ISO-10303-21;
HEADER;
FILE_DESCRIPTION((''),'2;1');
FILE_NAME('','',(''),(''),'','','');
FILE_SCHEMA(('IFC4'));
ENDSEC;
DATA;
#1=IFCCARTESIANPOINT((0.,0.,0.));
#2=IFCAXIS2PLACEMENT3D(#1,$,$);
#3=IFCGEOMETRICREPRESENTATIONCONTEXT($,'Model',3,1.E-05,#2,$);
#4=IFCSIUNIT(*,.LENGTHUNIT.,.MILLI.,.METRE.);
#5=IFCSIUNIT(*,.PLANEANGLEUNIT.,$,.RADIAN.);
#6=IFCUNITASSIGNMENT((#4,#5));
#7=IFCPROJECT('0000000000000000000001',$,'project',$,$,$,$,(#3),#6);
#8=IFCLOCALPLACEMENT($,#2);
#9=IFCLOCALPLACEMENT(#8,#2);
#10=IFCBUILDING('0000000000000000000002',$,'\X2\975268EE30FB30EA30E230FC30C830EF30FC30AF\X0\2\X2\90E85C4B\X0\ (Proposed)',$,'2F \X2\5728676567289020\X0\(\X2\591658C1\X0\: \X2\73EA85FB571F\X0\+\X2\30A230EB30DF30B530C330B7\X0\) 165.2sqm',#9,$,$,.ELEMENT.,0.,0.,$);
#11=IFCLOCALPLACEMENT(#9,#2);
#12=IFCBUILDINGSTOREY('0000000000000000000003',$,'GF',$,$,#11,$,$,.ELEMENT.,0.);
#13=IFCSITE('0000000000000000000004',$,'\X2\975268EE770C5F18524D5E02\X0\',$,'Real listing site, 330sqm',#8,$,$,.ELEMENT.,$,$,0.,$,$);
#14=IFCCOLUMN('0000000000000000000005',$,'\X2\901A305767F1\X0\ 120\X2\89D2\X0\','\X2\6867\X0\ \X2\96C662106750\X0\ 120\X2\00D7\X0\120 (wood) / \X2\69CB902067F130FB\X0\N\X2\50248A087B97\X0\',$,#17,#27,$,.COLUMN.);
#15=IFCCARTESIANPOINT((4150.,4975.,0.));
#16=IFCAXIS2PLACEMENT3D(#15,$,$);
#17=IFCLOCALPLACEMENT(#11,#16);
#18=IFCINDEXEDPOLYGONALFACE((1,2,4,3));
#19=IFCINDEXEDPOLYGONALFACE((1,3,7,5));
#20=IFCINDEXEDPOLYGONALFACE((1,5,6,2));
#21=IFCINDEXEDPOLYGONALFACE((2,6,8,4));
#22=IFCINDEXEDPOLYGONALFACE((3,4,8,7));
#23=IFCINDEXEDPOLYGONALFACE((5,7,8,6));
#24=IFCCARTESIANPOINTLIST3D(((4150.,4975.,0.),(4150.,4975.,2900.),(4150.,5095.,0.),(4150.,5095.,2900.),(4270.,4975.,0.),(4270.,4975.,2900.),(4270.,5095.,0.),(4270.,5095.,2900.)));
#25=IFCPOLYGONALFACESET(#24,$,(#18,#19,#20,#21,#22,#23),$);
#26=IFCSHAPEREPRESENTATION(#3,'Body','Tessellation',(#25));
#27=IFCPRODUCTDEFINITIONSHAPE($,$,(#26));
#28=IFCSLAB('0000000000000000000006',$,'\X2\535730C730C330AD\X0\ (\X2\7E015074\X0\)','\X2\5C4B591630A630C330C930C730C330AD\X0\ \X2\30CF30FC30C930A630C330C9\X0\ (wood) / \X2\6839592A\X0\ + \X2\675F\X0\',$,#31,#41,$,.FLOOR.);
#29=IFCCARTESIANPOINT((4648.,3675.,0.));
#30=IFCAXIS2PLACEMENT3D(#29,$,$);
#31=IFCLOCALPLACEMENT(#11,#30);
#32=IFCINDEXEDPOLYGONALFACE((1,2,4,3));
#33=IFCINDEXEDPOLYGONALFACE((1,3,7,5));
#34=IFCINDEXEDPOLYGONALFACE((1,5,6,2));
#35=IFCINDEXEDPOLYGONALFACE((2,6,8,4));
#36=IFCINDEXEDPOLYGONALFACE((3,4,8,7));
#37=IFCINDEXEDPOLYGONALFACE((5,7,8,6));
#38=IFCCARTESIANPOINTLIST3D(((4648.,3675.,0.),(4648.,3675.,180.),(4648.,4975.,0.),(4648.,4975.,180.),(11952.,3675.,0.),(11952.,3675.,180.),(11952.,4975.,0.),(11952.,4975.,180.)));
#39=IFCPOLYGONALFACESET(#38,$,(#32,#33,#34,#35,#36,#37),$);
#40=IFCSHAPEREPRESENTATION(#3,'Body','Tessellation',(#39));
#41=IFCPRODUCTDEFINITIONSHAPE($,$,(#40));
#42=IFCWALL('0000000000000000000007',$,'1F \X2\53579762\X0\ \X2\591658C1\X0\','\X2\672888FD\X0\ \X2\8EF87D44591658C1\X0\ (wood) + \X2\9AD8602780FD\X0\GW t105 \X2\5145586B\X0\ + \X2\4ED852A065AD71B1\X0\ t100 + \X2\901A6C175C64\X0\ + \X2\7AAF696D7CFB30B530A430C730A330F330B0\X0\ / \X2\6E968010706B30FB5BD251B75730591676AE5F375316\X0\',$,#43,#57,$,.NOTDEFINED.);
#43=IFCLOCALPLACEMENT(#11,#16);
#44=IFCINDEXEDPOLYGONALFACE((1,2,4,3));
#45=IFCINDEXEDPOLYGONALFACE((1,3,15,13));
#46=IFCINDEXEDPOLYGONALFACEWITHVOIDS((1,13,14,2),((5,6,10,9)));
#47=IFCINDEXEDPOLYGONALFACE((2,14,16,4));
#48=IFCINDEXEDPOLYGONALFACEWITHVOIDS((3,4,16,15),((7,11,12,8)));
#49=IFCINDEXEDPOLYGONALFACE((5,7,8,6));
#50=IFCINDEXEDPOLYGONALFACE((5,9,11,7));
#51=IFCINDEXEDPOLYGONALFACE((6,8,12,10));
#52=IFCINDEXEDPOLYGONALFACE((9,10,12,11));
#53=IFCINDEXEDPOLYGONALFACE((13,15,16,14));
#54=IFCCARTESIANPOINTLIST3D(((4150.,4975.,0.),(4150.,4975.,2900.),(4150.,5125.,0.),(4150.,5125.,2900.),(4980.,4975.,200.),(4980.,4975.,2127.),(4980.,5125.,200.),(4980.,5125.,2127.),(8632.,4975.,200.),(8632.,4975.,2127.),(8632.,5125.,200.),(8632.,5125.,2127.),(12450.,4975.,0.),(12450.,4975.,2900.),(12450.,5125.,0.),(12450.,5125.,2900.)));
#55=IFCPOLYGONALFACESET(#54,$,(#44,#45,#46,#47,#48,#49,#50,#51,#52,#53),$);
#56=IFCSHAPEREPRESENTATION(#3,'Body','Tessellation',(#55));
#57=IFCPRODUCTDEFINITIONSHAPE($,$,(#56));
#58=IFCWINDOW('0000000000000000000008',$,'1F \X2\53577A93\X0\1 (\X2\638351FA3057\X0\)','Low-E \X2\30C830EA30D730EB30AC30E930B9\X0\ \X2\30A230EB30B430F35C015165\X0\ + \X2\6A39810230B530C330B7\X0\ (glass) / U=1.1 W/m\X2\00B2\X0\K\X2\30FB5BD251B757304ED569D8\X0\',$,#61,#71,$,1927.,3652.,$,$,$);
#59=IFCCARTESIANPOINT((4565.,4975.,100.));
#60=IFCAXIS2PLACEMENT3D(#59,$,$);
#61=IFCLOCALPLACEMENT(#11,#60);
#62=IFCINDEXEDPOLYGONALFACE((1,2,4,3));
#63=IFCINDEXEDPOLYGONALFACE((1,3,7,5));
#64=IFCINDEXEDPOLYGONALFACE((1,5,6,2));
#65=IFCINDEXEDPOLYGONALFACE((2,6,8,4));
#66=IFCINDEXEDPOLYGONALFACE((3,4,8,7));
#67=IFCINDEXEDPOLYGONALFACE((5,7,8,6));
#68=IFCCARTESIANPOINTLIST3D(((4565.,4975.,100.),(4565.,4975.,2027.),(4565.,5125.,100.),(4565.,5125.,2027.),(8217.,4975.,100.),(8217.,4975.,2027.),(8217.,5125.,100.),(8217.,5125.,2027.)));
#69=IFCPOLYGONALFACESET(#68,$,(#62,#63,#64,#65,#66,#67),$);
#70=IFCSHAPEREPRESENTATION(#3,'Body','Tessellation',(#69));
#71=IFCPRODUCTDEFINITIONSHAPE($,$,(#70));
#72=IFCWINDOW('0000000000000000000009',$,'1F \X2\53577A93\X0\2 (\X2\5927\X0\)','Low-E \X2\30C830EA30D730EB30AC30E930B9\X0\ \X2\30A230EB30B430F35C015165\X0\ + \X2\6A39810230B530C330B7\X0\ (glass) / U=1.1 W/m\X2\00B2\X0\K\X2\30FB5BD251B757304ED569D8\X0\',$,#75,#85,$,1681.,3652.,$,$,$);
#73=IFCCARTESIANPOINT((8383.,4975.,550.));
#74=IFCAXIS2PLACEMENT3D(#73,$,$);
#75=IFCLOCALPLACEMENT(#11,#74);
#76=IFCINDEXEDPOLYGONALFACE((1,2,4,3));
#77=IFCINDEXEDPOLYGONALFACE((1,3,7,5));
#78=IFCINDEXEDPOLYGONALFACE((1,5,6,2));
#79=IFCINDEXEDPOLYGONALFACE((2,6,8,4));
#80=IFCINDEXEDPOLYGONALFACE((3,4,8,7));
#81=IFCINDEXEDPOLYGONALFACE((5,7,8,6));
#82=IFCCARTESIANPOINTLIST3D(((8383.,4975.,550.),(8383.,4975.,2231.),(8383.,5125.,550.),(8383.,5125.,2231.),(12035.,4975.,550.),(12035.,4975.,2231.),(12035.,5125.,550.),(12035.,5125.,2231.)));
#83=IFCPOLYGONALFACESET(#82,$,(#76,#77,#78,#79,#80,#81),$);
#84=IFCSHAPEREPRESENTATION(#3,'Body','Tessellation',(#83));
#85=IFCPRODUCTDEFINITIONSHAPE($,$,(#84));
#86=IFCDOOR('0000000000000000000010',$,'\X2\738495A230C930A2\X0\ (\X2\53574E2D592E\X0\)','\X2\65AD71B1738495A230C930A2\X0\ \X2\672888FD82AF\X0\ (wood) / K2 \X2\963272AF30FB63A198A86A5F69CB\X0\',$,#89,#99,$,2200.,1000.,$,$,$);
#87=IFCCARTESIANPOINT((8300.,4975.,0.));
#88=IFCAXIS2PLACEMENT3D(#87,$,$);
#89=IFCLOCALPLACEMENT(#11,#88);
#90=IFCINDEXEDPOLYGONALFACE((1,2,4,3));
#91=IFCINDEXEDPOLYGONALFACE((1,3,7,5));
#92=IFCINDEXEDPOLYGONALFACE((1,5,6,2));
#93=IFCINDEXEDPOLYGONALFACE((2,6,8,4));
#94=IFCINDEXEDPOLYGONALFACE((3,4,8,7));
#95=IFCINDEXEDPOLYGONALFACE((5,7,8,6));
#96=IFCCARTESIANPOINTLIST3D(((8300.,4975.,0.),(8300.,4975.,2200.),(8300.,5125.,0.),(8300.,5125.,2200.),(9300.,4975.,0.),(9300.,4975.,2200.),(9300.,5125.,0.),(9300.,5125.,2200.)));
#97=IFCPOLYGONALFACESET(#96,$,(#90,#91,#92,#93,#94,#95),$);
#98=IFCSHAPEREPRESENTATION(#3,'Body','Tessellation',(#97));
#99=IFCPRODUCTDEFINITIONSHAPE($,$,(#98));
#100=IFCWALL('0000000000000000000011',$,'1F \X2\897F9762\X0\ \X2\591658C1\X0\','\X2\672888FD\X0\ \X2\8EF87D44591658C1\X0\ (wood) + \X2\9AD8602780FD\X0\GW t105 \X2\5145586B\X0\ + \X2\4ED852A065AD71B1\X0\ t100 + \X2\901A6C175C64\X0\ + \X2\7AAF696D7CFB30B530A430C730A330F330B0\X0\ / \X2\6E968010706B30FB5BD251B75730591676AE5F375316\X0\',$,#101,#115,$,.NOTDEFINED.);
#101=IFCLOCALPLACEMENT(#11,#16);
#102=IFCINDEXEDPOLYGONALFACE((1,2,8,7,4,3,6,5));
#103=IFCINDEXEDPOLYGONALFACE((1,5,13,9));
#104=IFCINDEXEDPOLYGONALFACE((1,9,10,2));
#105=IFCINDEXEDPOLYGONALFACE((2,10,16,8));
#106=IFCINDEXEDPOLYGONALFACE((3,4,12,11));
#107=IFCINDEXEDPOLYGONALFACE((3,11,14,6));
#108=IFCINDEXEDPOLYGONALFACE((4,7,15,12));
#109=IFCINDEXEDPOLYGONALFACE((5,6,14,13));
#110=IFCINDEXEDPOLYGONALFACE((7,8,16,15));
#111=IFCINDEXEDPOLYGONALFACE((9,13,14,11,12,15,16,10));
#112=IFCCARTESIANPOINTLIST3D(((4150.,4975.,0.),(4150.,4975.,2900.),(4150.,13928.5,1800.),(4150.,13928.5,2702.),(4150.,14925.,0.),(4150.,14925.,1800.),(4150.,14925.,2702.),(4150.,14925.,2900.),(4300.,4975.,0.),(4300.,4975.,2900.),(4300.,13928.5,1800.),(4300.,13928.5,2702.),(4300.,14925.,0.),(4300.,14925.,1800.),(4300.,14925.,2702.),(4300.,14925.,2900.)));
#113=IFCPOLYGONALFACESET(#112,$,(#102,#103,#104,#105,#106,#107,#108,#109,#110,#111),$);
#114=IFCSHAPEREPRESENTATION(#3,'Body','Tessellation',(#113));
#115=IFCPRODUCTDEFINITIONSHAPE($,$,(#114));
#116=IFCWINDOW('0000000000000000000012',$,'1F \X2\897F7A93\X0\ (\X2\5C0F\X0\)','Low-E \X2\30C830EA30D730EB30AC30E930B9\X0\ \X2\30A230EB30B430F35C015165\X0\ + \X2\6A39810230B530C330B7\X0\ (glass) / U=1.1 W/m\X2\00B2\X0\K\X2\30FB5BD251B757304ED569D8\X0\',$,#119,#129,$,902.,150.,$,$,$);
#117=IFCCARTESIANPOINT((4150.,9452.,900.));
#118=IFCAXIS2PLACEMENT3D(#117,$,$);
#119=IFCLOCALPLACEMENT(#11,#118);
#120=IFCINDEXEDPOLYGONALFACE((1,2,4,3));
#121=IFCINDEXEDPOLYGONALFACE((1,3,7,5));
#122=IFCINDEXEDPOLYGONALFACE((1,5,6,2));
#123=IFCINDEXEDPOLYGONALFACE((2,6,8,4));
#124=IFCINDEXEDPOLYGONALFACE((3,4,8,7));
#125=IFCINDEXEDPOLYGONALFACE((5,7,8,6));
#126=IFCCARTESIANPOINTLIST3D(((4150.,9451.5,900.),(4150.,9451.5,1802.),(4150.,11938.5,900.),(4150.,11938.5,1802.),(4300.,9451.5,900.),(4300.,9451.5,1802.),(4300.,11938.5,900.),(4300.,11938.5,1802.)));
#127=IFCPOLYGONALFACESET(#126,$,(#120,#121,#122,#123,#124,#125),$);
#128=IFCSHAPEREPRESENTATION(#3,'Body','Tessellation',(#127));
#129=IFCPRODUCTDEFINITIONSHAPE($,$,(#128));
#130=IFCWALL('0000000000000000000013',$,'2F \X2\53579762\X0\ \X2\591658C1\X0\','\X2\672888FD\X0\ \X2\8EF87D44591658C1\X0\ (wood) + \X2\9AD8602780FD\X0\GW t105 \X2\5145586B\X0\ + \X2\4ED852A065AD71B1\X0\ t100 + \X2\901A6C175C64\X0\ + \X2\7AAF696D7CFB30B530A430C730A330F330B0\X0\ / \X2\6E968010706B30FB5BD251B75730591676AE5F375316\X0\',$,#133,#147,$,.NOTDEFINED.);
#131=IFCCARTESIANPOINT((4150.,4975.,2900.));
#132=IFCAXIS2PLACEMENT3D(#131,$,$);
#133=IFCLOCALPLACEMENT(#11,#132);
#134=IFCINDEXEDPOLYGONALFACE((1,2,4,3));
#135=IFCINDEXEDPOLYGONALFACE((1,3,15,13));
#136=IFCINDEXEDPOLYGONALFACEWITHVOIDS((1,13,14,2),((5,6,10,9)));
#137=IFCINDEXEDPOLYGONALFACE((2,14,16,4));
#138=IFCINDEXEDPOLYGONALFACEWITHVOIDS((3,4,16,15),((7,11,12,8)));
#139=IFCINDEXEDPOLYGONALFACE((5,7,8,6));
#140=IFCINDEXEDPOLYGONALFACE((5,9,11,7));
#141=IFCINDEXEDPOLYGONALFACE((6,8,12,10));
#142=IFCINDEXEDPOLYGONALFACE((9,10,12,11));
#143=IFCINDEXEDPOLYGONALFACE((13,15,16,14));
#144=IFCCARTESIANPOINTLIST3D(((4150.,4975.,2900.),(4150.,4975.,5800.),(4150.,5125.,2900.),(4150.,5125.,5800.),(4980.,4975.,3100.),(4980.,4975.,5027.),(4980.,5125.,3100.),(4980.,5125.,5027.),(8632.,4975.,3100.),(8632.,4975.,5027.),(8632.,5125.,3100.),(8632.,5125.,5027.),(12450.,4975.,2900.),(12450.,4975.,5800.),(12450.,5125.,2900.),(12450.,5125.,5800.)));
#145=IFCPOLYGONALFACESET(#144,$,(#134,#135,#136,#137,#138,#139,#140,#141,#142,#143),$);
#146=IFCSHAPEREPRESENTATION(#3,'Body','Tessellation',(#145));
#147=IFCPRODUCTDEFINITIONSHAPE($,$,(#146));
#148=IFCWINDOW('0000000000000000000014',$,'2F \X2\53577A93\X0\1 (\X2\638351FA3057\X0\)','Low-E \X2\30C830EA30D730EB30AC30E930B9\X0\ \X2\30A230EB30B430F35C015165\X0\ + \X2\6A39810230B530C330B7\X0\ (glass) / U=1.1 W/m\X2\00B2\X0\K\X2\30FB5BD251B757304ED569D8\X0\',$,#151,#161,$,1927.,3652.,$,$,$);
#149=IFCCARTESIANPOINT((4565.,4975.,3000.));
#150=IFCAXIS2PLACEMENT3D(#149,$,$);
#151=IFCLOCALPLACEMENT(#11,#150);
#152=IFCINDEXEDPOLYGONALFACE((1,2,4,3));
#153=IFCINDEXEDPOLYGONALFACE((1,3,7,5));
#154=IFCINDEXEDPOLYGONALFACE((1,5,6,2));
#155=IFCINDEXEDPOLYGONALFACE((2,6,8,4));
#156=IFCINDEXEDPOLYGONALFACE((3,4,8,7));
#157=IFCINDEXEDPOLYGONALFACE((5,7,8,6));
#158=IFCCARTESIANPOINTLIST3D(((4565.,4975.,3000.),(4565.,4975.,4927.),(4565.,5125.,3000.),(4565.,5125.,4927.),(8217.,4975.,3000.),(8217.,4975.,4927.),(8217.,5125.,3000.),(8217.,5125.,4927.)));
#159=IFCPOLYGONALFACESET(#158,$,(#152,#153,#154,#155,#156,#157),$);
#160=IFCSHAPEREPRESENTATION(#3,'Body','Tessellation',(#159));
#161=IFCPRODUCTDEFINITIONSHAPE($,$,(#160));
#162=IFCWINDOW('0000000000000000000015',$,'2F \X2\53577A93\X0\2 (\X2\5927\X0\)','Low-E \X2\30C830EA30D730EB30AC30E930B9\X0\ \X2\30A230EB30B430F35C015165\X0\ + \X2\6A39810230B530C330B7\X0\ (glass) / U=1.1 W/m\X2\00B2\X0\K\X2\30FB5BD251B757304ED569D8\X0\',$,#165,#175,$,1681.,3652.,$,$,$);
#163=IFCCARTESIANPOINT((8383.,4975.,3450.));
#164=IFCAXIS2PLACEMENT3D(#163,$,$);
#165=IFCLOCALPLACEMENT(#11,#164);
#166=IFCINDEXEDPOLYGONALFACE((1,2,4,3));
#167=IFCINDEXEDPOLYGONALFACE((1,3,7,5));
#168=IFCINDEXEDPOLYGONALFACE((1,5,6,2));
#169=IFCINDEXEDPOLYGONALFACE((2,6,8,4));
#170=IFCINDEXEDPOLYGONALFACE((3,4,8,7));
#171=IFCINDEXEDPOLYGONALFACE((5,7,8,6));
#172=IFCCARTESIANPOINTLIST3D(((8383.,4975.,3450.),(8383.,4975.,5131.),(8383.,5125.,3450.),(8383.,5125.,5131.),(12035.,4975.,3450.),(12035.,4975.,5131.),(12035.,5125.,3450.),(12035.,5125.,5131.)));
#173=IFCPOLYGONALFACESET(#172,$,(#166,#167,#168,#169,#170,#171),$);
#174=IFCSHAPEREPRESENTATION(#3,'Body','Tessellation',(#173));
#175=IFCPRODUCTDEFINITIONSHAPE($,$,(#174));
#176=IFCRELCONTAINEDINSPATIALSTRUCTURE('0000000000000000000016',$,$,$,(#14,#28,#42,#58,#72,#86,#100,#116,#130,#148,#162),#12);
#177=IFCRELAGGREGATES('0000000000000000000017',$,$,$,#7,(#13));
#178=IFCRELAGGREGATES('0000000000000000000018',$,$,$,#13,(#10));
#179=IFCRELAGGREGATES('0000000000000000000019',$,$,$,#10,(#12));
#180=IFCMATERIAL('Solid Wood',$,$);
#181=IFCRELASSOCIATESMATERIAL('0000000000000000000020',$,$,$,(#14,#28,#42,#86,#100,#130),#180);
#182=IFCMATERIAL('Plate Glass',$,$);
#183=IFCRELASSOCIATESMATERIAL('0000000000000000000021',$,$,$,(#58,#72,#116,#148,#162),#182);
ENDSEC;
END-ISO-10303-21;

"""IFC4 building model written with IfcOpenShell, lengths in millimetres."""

from ifc_helpers import new_model, si_unit, frame, frame_2d, origin, place, context, project, spatial, rectangle, extrude, material, element, fill, save


model = new_model("IFC4")

# Units and contexts
model_context = context("Model", 3, precision=1e-05, world=origin())
ifc_project = project(units=[si_unit("LENGTHUNIT", "METRE", prefix="MILLI"), si_unit("PLANEANGLEUNIT", "RADIAN")], contexts=[model_context])

# Site, building, storey
site_placement = place(None, origin())
site = spatial("IfcSite", under=ifc_project, at=site_placement, Name="青森県弘前市", ObjectType="Real listing site, 330sqm", CompositionType="ELEMENT", RefElevation=0.0)
building_placement = place(site_placement, origin())
building = spatial("IfcBuilding", under=site, at=building_placement, Name="青森・リモートワーク2部屋 (Proposed)", ObjectType="2F 在来木造(外壁: 珪藻土+アルミサッシ) 165.2sqm", CompositionType="ELEMENT", ElevationOfRefHeight=0.0, ElevationOfTerrain=0.0)
storey_placement = place(building_placement, origin())
storey = spatial("IfcBuildingStorey", under=building, at=storey_placement, Name="GF", CompositionType="ELEMENT", Elevation=0.0)

# Column
ifc_material_1 = material(Name="Solid Wood")
column_placement = place(storey_placement, frame((4150.0, 4975.0, 0.0)))
element("IfcColumn", 1, at=column_placement, inside=storey, material=ifc_material_1, Name="通し柱 120角", Description="桧 集成材 120×120 (wood) / 構造柱・N値計算", PredefinedType="COLUMN", context=model_context, shape_type="SweptSolid", body=[
    extrude(rectangle(XDim=120.0, YDim=120.0, at=frame_2d((60.0, 60.0))), frame((4150.0, 4975.0, 0.0)), (0.0, 0.0, 1.0), 2900.0),
])

# Slab
slab_1_placement = place(storey_placement, frame((4648.0, 3675.0, 0.0)))
element("IfcSlab", 2, at=slab_1_placement, inside=storey, material=ifc_material_1, Name="南デッキ (縁側)", Description="屋外ウッドデッキ ハードウッド (wood) / 根太 + 束", PredefinedType="FLOOR", context=model_context, shape_type="SweptSolid", body=[
    extrude(rectangle(XDim=7304.0, YDim=1300.0, at=frame_2d((3652.0, 650.0))), frame((4648.0, 3675.0, 0.0)), (0.0, 0.0, 1.0), 180.0),
])

# Wall, openings, windows, door
wall_1_placement = place(storey_placement, frame((4150.0, 4975.0, 0.0)))
wall_1 = element("IfcWall", 3, at=wall_1_placement, inside=storey, material=ifc_material_1, Name="1F 南面 外壁", Description="木製 軸組外壁 (wood) + 高性能GW t105 充填 + 付加断熱 t100 + 通気層 + 窯業系サイディング / 準耐火・寒冷地外皮強化", PredefinedType="NOTDEFINED", context=model_context, shape_type="SweptSolid", body=[
    extrude(rectangle(XDim=8300.0, YDim=150.0, at=frame_2d((4150.0, 75.0))), frame((4150.0, 4975.0, 0.0)), (0.0, 0.0, 1.0), 2900.0),
])
opening_1_placement = place(storey_placement, frame((4565.0, 4975.0, 100.0)))
opening_1 = element("IfcOpeningElement", 4, at=opening_1_placement, cuts=wall_1, PredefinedType="NOTDEFINED", context=model_context, shape_type="SweptSolid", body=[
    extrude(rectangle(XDim=3652.0, YDim=150.0, at=frame_2d((1826.0, 75.0))), frame((4565.0, 4975.0, 100.0)), (0.0, 0.0, 1.0), 1927.0),
])
opening_2_placement = place(storey_placement, frame((8383.0, 4975.0, 550.0)))
opening_2 = element("IfcOpeningElement", 5, at=opening_2_placement, cuts=wall_1, PredefinedType="NOTDEFINED", context=model_context, shape_type="SweptSolid", body=[
    extrude(rectangle(XDim=3652.0, YDim=150.0, at=frame_2d((1826.0, 75.0))), frame((8383.0, 4975.0, 550.0)), (0.0, 0.0, 1.0), 1681.0),
])
opening_3_placement = place(storey_placement, frame((8300.0, 4975.0, 0.0)))
opening_3 = element("IfcOpeningElement", 6, at=opening_3_placement, cuts=wall_1, PredefinedType="NOTDEFINED", context=model_context, shape_type="SweptSolid", body=[
    extrude(rectangle(XDim=1000.0, YDim=150.0, at=frame_2d((500.0, 75.0))), frame((8300.0, 4975.0, 0.0)), (0.0, 0.0, 1.0), 2200.0),
])
ifc_material_2 = material(Name="Plate Glass")
window_1_placement = place(storey_placement, frame((4565.0, 4975.0, 100.0)))
window_1 = element("IfcWindow", 7, at=window_1_placement, inside=storey, material=ifc_material_2, Name="1F 南窓1 (掃出し)", Description="Low-E トリプルガラス アルゴン封入 + 樹脂サッシ (glass) / U=1.1 W/m²K・寒冷地仕様", OverallHeight=1927.0, OverallWidth=3652.0, context=model_context, shape_type="SweptSolid", body=[
    extrude(rectangle(XDim=3652.0, YDim=150.0, at=frame_2d((1826.0, 75.0))), frame((4565.0, 4975.0, 100.0)), (0.0, 0.0, 1.0), 1927.0),
])
fill(opening_1, window_1)
window_2_placement = place(storey_placement, frame((8383.0, 4975.0, 550.0)))
window_2 = element("IfcWindow", 8, at=window_2_placement, inside=storey, material=ifc_material_2, Name="1F 南窓2 (大)", Description="Low-E トリプルガラス アルゴン封入 + 樹脂サッシ (glass) / U=1.1 W/m²K・寒冷地仕様", OverallHeight=1681.0, OverallWidth=3652.0, context=model_context, shape_type="SweptSolid", body=[
    extrude(rectangle(XDim=3652.0, YDim=150.0, at=frame_2d((1826.0, 75.0))), frame((8383.0, 4975.0, 550.0)), (0.0, 0.0, 1.0), 1681.0),
])
fill(opening_2, window_2)
door_placement = place(storey_placement, frame((8300.0, 4975.0, 0.0)))
door = element("IfcDoor", 9, at=door_placement, inside=storey, material=ifc_material_1, Name="玄関ドア (南中央)", Description="断熱玄関ドア 木製芯 (wood) / K2 防犯・採風機構", OverallHeight=2200.0, OverallWidth=1000.0, context=model_context, shape_type="SweptSolid", body=[
    extrude(rectangle(XDim=1000.0, YDim=150.0, at=frame_2d((500.0, 75.0))), frame((8300.0, 4975.0, 0.0)), (0.0, 0.0, 1.0), 2200.0),
])
fill(opening_3, door)

# Wall, opening, window
wall_2_placement = place(storey_placement, frame((4150.0, 4975.0, 0.0)))
wall_2 = element("IfcWall", 10, at=wall_2_placement, inside=storey, material=ifc_material_1, Name="1F 西面 外壁", Description="木製 軸組外壁 (wood) + 高性能GW t105 充填 + 付加断熱 t100 + 通気層 + 窯業系サイディング / 準耐火・寒冷地外皮強化", PredefinedType="NOTDEFINED", context=model_context, shape_type="SweptSolid", body=[
    extrude(rectangle(XDim=150.0, YDim=9950.0, at=frame_2d((75.0, 4975.0))), frame((4150.0, 4975.0, 0.0)), (0.0, 0.0, 1.0), 2900.0),
])
opening_4_placement = place(storey_placement, frame((4150.0, 9452.0, 900.0)))
opening_4 = element("IfcOpeningElement", 11, at=opening_4_placement, cuts=wall_2, PredefinedType="NOTDEFINED", context=model_context, shape_type="SweptSolid", body=[
    extrude(rectangle(XDim=150.0, YDim=2487.0, at=frame_2d((75.0, 1243.0))), frame((4150.0, 9452.0, 900.0)), (0.0, 0.0, 1.0), 902.0),
])
window_3_placement = place(storey_placement, frame((4150.0, 9452.0, 900.0)))
window_3 = element("IfcWindow", 12, at=window_3_placement, inside=storey, material=ifc_material_2, Name="1F 西窓 (小)", Description="Low-E トリプルガラス アルゴン封入 + 樹脂サッシ (glass) / U=1.1 W/m²K・寒冷地仕様", OverallHeight=902.0, OverallWidth=150.0, context=model_context, shape_type="SweptSolid", body=[
    extrude(rectangle(XDim=150.0, YDim=2487.0, at=frame_2d((75.0, 1243.0))), frame((4150.0, 9452.0, 900.0)), (0.0, 0.0, 1.0), 902.0),
])
fill(opening_4, window_3)

# Wall, openings, windows
wall_3_placement = place(storey_placement, frame((4150.0, 4975.0, 2900.0)))
wall_3 = element("IfcWall", 13, at=wall_3_placement, inside=storey, material=ifc_material_1, Name="2F 南面 外壁", Description="木製 軸組外壁 (wood) + 高性能GW t105 充填 + 付加断熱 t100 + 通気層 + 窯業系サイディング / 準耐火・寒冷地外皮強化", PredefinedType="NOTDEFINED", context=model_context, shape_type="SweptSolid", body=[
    extrude(rectangle(XDim=8300.0, YDim=150.0, at=frame_2d((4150.0, 75.0))), frame((4150.0, 4975.0, 2900.0)), (0.0, 0.0, 1.0), 2900.0),
])
opening_5_placement = place(storey_placement, frame((4565.0, 4975.0, 3000.0)))
opening_5 = element("IfcOpeningElement", 14, at=opening_5_placement, cuts=wall_3, PredefinedType="NOTDEFINED", context=model_context, shape_type="SweptSolid", body=[
    extrude(rectangle(XDim=3652.0, YDim=150.0, at=frame_2d((1826.0, 75.0))), frame((4565.0, 4975.0, 3000.0)), (0.0, 0.0, 1.0), 1927.0),
])
opening_6_placement = place(storey_placement, frame((8383.0, 4975.0, 3450.0)))
opening_6 = element("IfcOpeningElement", 15, at=opening_6_placement, cuts=wall_3, PredefinedType="NOTDEFINED", context=model_context, shape_type="SweptSolid", body=[
    extrude(rectangle(XDim=3652.0, YDim=150.0, at=frame_2d((1826.0, 75.0))), frame((8383.0, 4975.0, 3450.0)), (0.0, 0.0, 1.0), 1681.0),
])
window_4_placement = place(storey_placement, frame((4565.0, 4975.0, 3000.0)))
window_4 = element("IfcWindow", 16, at=window_4_placement, inside=storey, material=ifc_material_2, Name="2F 南窓1 (掃出し)", Description="Low-E トリプルガラス アルゴン封入 + 樹脂サッシ (glass) / U=1.1 W/m²K・寒冷地仕様", OverallHeight=1927.0, OverallWidth=3652.0, context=model_context, shape_type="SweptSolid", body=[
    extrude(rectangle(XDim=3652.0, YDim=150.0, at=frame_2d((1826.0, 75.0))), frame((4565.0, 4975.0, 3000.0)), (0.0, 0.0, 1.0), 1927.0),
])
fill(opening_5, window_4)
window_5_placement = place(storey_placement, frame((8383.0, 4975.0, 3450.0)))
window_5 = element("IfcWindow", 17, at=window_5_placement, inside=storey, material=ifc_material_2, Name="2F 南窓2 (大)", Description="Low-E トリプルガラス アルゴン封入 + 樹脂サッシ (glass) / U=1.1 W/m²K・寒冷地仕様", OverallHeight=1681.0, OverallWidth=3652.0, context=model_context, shape_type="SweptSolid", body=[
    extrude(rectangle(XDim=3652.0, YDim=150.0, at=frame_2d((1826.0, 75.0))), frame((8383.0, 4975.0, 3450.0)), (0.0, 0.0, 1.0), 1681.0),
])
fill(opening_6, window_5)

save(model, "model.ifc")
